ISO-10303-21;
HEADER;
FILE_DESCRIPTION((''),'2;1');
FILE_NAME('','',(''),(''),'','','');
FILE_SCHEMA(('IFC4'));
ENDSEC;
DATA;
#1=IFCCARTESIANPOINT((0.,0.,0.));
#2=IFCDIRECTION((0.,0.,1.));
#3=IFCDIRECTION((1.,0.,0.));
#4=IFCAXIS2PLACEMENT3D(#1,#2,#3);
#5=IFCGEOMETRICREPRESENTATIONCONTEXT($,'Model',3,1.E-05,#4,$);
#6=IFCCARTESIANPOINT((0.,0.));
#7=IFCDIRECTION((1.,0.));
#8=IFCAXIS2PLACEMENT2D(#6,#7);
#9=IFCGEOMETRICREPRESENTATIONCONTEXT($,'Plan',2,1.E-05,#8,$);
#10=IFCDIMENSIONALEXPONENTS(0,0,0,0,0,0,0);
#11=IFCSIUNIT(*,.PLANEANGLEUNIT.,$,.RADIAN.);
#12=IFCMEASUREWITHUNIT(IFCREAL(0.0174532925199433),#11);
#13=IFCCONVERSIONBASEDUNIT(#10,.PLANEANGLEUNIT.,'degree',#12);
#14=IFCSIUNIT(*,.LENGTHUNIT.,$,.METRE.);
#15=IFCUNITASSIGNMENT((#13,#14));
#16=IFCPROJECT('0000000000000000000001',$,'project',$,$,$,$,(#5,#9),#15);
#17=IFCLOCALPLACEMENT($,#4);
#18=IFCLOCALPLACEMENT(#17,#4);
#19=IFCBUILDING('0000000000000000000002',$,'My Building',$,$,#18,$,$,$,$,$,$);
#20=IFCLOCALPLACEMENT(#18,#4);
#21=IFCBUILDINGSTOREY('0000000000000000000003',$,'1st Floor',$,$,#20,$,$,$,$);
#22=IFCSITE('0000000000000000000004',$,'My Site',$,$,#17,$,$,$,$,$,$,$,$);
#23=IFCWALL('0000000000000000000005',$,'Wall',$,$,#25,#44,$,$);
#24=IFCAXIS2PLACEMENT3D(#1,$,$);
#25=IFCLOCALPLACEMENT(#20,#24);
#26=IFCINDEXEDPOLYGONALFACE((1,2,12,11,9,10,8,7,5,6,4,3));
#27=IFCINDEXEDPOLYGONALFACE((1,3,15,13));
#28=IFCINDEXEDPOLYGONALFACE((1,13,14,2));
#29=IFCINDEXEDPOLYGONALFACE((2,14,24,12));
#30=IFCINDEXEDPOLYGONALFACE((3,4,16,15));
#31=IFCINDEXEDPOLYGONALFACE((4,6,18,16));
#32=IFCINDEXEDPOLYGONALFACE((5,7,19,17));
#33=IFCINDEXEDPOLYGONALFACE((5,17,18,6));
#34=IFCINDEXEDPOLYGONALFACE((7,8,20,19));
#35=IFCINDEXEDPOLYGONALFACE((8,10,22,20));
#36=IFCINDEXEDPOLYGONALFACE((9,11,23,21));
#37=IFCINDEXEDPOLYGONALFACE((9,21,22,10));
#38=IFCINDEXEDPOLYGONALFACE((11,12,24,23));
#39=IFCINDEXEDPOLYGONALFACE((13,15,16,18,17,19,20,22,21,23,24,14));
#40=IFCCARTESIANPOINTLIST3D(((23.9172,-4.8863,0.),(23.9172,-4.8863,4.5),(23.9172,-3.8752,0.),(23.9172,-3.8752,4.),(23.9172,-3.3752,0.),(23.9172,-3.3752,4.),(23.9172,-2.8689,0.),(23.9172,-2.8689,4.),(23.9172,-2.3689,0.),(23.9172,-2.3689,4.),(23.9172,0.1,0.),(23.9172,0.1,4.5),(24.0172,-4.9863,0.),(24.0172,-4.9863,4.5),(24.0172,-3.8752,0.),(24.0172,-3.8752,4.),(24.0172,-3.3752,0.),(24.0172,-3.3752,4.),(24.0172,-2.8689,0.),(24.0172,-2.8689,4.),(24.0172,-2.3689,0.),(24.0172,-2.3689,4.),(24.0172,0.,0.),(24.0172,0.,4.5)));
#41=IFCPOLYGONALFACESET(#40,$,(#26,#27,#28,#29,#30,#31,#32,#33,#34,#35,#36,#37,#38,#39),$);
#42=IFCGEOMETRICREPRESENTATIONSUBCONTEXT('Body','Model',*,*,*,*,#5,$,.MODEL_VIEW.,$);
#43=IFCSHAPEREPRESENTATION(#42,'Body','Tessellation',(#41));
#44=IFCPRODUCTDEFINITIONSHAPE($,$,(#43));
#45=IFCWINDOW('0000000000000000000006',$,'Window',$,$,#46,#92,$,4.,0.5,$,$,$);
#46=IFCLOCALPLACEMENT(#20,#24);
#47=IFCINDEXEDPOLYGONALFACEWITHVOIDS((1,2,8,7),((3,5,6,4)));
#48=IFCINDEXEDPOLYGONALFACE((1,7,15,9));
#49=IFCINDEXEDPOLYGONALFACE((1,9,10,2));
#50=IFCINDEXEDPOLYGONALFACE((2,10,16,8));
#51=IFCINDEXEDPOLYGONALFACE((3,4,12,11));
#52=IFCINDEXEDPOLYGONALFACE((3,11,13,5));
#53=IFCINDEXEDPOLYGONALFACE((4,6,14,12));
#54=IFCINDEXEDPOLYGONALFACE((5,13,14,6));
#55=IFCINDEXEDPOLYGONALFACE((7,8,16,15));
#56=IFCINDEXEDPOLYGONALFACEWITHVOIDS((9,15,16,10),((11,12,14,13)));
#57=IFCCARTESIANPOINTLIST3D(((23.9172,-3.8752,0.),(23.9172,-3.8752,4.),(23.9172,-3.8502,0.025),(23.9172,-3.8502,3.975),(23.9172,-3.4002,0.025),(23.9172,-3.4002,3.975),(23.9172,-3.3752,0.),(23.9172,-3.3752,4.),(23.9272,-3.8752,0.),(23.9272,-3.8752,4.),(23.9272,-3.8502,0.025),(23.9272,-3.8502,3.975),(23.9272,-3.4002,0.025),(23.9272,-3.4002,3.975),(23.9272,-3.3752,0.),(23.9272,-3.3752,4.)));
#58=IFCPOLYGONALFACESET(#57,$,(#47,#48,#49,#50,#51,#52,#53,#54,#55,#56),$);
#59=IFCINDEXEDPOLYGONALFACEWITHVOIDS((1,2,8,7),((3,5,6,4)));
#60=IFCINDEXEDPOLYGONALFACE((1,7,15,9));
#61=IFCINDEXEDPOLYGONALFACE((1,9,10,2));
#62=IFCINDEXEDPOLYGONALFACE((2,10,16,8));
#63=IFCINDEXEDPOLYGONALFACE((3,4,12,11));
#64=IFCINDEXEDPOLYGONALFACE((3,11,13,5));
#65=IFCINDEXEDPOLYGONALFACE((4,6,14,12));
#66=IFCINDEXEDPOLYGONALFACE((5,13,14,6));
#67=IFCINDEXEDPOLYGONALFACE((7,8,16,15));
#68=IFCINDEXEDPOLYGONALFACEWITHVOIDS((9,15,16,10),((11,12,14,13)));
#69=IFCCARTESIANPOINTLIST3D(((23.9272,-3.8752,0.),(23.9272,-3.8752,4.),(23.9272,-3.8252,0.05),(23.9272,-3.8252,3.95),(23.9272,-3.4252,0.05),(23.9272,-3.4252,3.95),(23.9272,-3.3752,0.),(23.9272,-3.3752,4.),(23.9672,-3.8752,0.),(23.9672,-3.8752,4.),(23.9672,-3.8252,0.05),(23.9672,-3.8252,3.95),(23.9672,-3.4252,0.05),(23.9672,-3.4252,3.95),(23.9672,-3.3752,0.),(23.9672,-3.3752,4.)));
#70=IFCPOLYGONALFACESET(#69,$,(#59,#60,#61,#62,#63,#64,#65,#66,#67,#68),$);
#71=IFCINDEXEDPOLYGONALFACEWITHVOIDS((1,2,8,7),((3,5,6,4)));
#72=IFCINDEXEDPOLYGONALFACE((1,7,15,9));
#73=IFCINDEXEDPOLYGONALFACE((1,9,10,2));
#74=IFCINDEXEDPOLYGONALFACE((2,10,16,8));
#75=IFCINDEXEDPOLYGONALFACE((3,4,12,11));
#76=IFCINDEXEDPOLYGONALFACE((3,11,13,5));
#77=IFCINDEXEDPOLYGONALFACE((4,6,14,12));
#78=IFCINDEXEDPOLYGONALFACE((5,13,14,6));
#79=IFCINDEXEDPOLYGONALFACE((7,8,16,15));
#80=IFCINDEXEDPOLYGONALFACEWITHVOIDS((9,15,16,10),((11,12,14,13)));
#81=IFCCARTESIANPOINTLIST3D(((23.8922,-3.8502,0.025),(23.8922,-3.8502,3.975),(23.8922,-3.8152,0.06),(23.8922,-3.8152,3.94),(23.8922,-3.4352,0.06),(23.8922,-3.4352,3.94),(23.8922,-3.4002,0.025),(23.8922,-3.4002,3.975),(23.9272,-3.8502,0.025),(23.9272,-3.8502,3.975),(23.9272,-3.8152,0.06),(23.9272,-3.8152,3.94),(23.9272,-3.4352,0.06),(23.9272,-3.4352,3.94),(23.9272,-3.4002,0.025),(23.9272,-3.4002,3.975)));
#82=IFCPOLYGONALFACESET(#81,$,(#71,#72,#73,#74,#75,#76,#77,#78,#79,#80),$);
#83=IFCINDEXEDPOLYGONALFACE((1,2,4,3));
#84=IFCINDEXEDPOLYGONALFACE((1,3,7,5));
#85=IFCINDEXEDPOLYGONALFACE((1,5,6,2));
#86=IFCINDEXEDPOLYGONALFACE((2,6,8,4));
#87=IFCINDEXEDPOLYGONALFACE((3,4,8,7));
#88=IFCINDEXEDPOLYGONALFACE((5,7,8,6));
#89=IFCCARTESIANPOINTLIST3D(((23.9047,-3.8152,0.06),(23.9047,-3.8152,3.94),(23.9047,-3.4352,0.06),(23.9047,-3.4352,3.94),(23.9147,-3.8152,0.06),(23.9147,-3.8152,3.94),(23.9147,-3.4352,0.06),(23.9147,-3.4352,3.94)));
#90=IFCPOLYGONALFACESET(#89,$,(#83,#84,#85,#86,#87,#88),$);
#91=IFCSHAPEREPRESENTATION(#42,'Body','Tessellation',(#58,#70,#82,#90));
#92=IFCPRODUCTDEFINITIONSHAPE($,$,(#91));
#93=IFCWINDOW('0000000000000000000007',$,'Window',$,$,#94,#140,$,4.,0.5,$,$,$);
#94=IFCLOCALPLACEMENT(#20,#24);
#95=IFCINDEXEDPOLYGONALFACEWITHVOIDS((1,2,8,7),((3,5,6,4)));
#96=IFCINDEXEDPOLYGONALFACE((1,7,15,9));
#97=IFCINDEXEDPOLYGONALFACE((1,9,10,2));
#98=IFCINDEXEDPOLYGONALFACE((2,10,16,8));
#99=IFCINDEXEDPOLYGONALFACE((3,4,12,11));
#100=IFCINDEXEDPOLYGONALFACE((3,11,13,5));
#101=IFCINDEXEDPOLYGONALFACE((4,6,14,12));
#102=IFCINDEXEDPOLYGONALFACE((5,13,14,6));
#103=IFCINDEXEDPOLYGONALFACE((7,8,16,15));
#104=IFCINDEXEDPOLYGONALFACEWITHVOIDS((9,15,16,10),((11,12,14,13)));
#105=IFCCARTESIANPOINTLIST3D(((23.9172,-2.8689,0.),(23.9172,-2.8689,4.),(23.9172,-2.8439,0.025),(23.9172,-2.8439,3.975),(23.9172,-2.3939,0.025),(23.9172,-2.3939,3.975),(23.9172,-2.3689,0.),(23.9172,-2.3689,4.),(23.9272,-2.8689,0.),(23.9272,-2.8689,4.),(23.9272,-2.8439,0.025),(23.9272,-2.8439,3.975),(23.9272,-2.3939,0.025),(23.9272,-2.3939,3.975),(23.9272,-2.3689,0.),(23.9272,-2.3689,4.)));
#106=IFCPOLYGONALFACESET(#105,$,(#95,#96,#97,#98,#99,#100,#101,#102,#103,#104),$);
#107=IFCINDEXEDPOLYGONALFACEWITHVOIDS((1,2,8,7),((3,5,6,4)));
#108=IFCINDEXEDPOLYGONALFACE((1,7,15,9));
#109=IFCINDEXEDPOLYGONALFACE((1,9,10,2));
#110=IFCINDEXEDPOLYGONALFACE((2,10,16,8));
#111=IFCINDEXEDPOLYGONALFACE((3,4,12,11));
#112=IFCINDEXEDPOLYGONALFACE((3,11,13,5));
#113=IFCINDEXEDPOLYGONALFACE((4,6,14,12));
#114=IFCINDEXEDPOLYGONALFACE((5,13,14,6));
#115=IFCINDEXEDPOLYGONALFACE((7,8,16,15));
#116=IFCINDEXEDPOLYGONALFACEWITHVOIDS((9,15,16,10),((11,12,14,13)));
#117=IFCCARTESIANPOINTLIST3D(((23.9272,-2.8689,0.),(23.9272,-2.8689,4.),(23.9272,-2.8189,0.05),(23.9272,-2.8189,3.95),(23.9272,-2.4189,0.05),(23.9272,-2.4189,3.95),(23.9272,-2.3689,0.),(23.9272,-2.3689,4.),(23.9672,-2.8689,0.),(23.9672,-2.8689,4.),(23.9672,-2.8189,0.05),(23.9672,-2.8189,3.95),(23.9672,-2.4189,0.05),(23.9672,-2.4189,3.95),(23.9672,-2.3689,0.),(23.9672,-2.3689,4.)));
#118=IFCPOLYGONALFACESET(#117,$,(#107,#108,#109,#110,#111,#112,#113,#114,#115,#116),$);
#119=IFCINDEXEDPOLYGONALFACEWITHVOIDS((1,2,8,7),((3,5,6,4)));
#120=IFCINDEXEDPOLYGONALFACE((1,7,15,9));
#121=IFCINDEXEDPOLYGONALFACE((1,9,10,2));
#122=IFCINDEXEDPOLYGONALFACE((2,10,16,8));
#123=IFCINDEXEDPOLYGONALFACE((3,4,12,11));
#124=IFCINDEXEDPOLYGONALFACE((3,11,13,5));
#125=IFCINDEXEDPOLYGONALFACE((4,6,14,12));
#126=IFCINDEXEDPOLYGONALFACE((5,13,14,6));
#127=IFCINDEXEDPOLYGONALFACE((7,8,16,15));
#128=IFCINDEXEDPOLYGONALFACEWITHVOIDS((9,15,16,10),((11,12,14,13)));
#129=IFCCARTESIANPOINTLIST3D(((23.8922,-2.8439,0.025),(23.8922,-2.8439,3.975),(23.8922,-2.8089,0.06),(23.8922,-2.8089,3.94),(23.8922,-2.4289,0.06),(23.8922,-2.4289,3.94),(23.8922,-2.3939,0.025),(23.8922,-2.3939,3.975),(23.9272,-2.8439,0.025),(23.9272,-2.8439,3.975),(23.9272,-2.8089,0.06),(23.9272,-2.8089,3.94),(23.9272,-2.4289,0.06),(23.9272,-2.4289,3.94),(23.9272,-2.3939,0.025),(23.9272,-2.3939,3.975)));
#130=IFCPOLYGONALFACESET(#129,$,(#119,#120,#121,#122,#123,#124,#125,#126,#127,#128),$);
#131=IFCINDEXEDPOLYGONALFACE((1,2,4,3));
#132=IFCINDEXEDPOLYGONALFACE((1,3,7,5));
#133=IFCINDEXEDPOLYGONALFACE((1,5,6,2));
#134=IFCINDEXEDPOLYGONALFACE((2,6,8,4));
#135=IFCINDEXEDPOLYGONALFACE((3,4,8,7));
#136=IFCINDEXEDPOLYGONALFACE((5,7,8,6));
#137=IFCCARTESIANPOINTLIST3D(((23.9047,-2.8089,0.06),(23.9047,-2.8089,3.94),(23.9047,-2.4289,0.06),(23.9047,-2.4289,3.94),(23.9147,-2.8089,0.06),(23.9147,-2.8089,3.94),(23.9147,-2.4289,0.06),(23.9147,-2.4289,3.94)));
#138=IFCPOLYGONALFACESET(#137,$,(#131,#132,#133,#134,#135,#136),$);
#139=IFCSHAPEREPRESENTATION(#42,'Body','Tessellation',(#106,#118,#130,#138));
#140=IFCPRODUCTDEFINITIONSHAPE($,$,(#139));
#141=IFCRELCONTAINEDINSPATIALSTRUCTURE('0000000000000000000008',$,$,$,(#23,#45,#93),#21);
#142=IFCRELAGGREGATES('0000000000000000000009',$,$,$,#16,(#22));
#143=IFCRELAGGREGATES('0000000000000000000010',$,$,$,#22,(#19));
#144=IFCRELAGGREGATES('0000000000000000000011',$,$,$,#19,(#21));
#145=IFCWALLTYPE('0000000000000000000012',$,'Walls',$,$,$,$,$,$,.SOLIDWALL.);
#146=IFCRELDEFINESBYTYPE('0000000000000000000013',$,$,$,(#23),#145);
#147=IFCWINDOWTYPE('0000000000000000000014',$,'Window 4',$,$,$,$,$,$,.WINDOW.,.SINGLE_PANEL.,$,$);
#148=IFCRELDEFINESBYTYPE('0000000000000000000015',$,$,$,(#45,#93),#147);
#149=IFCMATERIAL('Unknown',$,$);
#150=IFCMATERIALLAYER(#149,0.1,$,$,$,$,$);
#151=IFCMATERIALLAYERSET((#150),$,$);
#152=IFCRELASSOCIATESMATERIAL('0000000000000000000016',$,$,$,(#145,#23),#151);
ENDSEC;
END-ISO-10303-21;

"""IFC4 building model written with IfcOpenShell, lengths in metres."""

from ifc_helpers import new_model, entity, si_unit, converted_unit, frame, origin_with_axes, origin_2d_with_axis, place, context, subcontext, project, spatial, line, indexed_curve, outline, extrude, shape, source, transform, mapped, material, layer, layer_set, layer_usage, type_object, type_shapes, element, fill, save


model = new_model("IFC4")

# Units and contexts
model_context = context("Model", 3, precision=1e-05, world=origin_with_axes())
plan_context = context("Plan", 2, precision=1e-05, world=origin_2d_with_axis())
body_context_1 = subcontext(model_context, "Body", "Model", "MODEL_VIEW")
body_context_2 = subcontext(plan_context, "Body", "Plan", "PLAN_VIEW")
ifc_project = project(units=[converted_unit("PLANEANGLEUNIT", "degree", entity("IfcReal", 0.0174532925199433), si_unit("PLANEANGLEUNIT", "RADIAN"), dimensions=[0, 0, 0, 0, 0, 0, 0]), si_unit("LENGTHUNIT", "METRE")], contexts=[model_context, plan_context])

# Site, building, storey
site_placement = place(None, origin_with_axes())
site = spatial("IfcSite", under=ifc_project, at=site_placement, Name="My Site")
building_placement = place(site_placement, origin_with_axes())
building = spatial("IfcBuilding", under=site, at=building_placement, Name="My Building")
storey_placement = place(building_placement, origin_with_axes())
storey = spatial("IfcBuildingStorey", under=building, at=storey_placement, Name="1st Floor")

# Shared definitions
ifc_material = material(Name="Unknown")

# Wall, openings, windows
ifc_layer_1 = layer(ifc_material, 0.1)
ifc_layer_set_1 = layer_set([ifc_layer_1])
ifc_layer_usage_1 = layer_usage(ifc_layer_set_1, "AXIS2", "POSITIVE", 0.0)
wall_type_1 = type_object("IfcWallType", Name="Walls", PredefinedType="SOLIDWALL", material=ifc_layer_set_1)
wall_1_placement = place(storey_placement, frame((24.0172, -4.9863, 0.0), z_axis=(0.0, 0.0, 1.0), x_axis=(0.0, 1.0, 0.0)))
wall_1 = element("IfcWall", 1, at=wall_1_placement, inside=storey, type_object=wall_type_1, material=ifc_layer_usage_1, Name="Wall", context=body_context_1, shape_type="SweptSolid", body=[
    extrude(outline(indexed_curve([(0.0, 0.0), (0.1, 0.1), (5.0863, 0.1), (4.9863, 0.0)], segments=[line(1, 2, 3, 4, 1)])), origin_with_axes(), (0.0, 0.0, 1.0), 4.5),
])
shared_shape_1 = source(origin_with_axes(), body_context_1, "Body", "SweptSolid", [
    extrude(outline(indexed_curve([(0.0, 0.0), (0.5, 0.0), (0.5, 4.0), (0.0, 4.0)], segments=[line(1, 2, 3, 4, 1)])), frame((0.0, -0.6, 0.0), z_axis=(0.0, -1.0, 0.0), x_axis=(1.0, 0.0, 0.0)), (0.0, 0.0, -1.0), 1.2),
])
opening_1_placement = place(wall_1_placement, frame((1.1111, 0.0, 0.0), z_axis=(0.0, 0.0, 1.0), x_axis=(1.0, 0.0, 0.0)))
opening_1 = element("IfcOpeningElement", 2, at=opening_1_placement, cuts=wall_1, PredefinedType="OPENING", context=body_context_1, shape_type="MappedRepresentation", body=[
    mapped(shared_shape_1, transform((0.0, 0.0, 0.0), x_axis=(1.0, 0.0, 0.0), y_axis=(0.0, 1.0, 0.0), z_axis=(0.0, 0.0, 1.0), scale=1.0)),
])
opening_2_placement = place(wall_1_placement, frame((2.1174, 0.0, 0.0), z_axis=(0.0, 0.0, 1.0), x_axis=(1.0, 0.0, 0.0)))
opening_2 = element("IfcOpeningElement", 3, at=opening_2_placement, cuts=wall_1, PredefinedType="OPENING", context=body_context_1, shape_type="MappedRepresentation", body=[
    mapped(shared_shape_1, transform((0.0, 0.0, 0.0), x_axis=(1.0, 0.0, 0.0), y_axis=(0.0, 1.0, 0.0), z_axis=(0.0, 0.0, 1.0), scale=1.0)),
])
window_type_1 = type_object("IfcWindowType", Name="Window 4", PartitioningType="SINGLE_PANEL", PredefinedType="WINDOW")
shared_shape_2 = source(origin_with_axes(), body_context_1, "Body", "SweptSolid", [
    extrude(outline(indexed_curve([(0.0, 0.0), (0.5, 0.0), (0.5, 4.0), (0.0, 4.0)], segments=[line(1, 2, 3, 4, 1)]), holes=[indexed_curve([(0.025, 0.025), (0.475, 0.025), (0.475, 3.975), (0.025, 3.975)], segments=[line(1, 2, 3, 4, 1)])]), frame((0.0, 0.09, 0.0), z_axis=(0.0, -1.0, 0.0), x_axis=(1.0, 0.0, 0.0)), (0.0, 0.0, -1.0), 0.01),
    extrude(outline(indexed_curve([(0.0, 0.0), (0.5, 0.0), (0.5, 4.0), (0.0, 4.0)], segments=[line(1, 2, 3, 4, 1)]), holes=[indexed_curve([(0.05, 0.05), (0.45, 0.05), (0.45, 3.95), (0.05, 3.95)], segments=[line(1, 2, 3, 4, 1)])]), frame((0.0, 0.05, 0.0), z_axis=(0.0, -1.0, 0.0), x_axis=(1.0, 0.0, 0.0)), (0.0, 0.0, -1.0), 0.04),
    extrude(outline(indexed_curve([(0.0, 0.0), (0.45, 0.0), (0.45, 3.95), (0.0, 3.95)], segments=[line(1, 2, 3, 4, 1)]), holes=[indexed_curve([(0.035, 0.035), (0.415, 0.035), (0.415, 3.915), (0.035, 3.915)], segments=[line(1, 2, 3, 4, 1)])]), frame((0.025, 0.09, 0.025), z_axis=(0.0, -1.0, 0.0), x_axis=(1.0, 0.0, 0.0)), (0.0, 0.0, -1.0), 0.035),
    extrude(outline(indexed_curve([(0.035, 0.035), (0.415, 0.035), (0.415, 3.915), (0.035, 3.915)], segments=[line(1, 2, 3, 4, 1)])), frame((0.025, 0.1025, 0.025), z_axis=(0.0, -1.0, 0.0), x_axis=(1.0, 0.0, 0.0)), (0.0, 0.0, -1.0), 0.01),
])
shared_shape_3 = source(origin_with_axes(), body_context_2, "Body", "Curve2D", [
    entity("IfcIndexedPolyCurve", entity("IfcCartesianPointList2D", [[0.05, 0.05], [0.45, 0.05]])),
    entity("IfcIndexedPolyCurve", entity("IfcCartesianPointList2D", [[0.0, 0.1], [0.025, 0.1], [0.025, 0.09], [0.05, 0.09], [0.05, 0.05], [0.0, 0.05]]), [entity("IfcLineIndex", [1, 2, 3, 4, 5, 6, 1])]),
    entity("IfcIndexedPolyCurve", entity("IfcCartesianPointList2D", [[0.5, 0.1], [0.475, 0.1], [0.475, 0.09], [0.45, 0.09], [0.45, 0.05], [0.5, 0.05]]), [entity("IfcLineIndex", [1, 2, 3, 4, 5, 6, 1])]),
    entity("IfcIndexedPolyCurve", entity("IfcCartesianPointList2D", [[0.025, 0.09], [0.06, 0.09], [0.06, 0.125], [0.025, 0.125]]), [entity("IfcLineIndex", [1, 2, 3, 4, 1])]),
    entity("IfcIndexedPolyCurve", entity("IfcCartesianPointList2D", [[0.475, 0.09], [0.44, 0.09], [0.44, 0.125], [0.475, 0.125]]), [entity("IfcLineIndex", [1, 2, 3, 4, 1])]),
    entity("IfcIndexedPolyCurve", entity("IfcCartesianPointList2D", [[0.06, 0.09], [0.44, 0.09]])),
    entity("IfcIndexedPolyCurve", entity("IfcCartesianPointList2D", [[0.06, 0.125], [0.44, 0.125]])),
    entity("IfcIndexedPolyCurve", entity("IfcCartesianPointList2D", [[0.06, 0.1075], [0.44, 0.1075]])),
])
type_shapes(window_type_1, [shared_shape_2, shared_shape_3])
window_1_placement = place(opening_1_placement, frame((0.0, 0.0, 0.0), z_axis=(0.0, 0.0, 1.0), x_axis=(1.0, 0.0, 0.0)))
window_1 = element("IfcWindow", 4, at=window_1_placement, inside=storey, type_object=window_type_1, Name="Window", OverallHeight=4.0, OverallWidth=0.5, shapes=[
    shape(body_context_1, "Body", "MappedRepresentation", [mapped(shared_shape_2, transform((0.0, 0.0, 0.0), x_axis=(1.0, 0.0, 0.0), y_axis=(0.0, 1.0, 0.0), z_axis=(0.0, 0.0, 1.0), scale=1.0))]),
    shape(body_context_2, "Body", "MappedRepresentation", [mapped(shared_shape_3, transform((0.0, 0.0, 0.0), x_axis=(1.0, 0.0, 0.0), y_axis=(0.0, 1.0, 0.0), z_axis=(0.0, 0.0, 1.0), scale=1.0))]),
])
fill(opening_1, window_1)
window_2_placement = place(opening_2_placement, frame((0.0, 0.0, 0.0), z_axis=(0.0, 0.0, 1.0), x_axis=(1.0, 0.0, 0.0)))
window_2 = element("IfcWindow", 5, at=window_2_placement, inside=storey, type_object=window_type_1, Name="Window", OverallHeight=4.0, OverallWidth=0.5, shapes=[
    shape(body_context_1, "Body", "MappedRepresentation", [mapped(shared_shape_2, transform((0.0, 0.0, 0.0), x_axis=(1.0, 0.0, 0.0), y_axis=(0.0, 1.0, 0.0), z_axis=(0.0, 0.0, 1.0), scale=1.0))]),
    shape(body_context_2, "Body", "MappedRepresentation", [mapped(shared_shape_3, transform((0.0, 0.0, 0.0), x_axis=(1.0, 0.0, 0.0), y_axis=(0.0, 1.0, 0.0), z_axis=(0.0, 0.0, 1.0), scale=1.0))]),
])
fill(opening_2, window_2)

save(model, "model.ifc")
